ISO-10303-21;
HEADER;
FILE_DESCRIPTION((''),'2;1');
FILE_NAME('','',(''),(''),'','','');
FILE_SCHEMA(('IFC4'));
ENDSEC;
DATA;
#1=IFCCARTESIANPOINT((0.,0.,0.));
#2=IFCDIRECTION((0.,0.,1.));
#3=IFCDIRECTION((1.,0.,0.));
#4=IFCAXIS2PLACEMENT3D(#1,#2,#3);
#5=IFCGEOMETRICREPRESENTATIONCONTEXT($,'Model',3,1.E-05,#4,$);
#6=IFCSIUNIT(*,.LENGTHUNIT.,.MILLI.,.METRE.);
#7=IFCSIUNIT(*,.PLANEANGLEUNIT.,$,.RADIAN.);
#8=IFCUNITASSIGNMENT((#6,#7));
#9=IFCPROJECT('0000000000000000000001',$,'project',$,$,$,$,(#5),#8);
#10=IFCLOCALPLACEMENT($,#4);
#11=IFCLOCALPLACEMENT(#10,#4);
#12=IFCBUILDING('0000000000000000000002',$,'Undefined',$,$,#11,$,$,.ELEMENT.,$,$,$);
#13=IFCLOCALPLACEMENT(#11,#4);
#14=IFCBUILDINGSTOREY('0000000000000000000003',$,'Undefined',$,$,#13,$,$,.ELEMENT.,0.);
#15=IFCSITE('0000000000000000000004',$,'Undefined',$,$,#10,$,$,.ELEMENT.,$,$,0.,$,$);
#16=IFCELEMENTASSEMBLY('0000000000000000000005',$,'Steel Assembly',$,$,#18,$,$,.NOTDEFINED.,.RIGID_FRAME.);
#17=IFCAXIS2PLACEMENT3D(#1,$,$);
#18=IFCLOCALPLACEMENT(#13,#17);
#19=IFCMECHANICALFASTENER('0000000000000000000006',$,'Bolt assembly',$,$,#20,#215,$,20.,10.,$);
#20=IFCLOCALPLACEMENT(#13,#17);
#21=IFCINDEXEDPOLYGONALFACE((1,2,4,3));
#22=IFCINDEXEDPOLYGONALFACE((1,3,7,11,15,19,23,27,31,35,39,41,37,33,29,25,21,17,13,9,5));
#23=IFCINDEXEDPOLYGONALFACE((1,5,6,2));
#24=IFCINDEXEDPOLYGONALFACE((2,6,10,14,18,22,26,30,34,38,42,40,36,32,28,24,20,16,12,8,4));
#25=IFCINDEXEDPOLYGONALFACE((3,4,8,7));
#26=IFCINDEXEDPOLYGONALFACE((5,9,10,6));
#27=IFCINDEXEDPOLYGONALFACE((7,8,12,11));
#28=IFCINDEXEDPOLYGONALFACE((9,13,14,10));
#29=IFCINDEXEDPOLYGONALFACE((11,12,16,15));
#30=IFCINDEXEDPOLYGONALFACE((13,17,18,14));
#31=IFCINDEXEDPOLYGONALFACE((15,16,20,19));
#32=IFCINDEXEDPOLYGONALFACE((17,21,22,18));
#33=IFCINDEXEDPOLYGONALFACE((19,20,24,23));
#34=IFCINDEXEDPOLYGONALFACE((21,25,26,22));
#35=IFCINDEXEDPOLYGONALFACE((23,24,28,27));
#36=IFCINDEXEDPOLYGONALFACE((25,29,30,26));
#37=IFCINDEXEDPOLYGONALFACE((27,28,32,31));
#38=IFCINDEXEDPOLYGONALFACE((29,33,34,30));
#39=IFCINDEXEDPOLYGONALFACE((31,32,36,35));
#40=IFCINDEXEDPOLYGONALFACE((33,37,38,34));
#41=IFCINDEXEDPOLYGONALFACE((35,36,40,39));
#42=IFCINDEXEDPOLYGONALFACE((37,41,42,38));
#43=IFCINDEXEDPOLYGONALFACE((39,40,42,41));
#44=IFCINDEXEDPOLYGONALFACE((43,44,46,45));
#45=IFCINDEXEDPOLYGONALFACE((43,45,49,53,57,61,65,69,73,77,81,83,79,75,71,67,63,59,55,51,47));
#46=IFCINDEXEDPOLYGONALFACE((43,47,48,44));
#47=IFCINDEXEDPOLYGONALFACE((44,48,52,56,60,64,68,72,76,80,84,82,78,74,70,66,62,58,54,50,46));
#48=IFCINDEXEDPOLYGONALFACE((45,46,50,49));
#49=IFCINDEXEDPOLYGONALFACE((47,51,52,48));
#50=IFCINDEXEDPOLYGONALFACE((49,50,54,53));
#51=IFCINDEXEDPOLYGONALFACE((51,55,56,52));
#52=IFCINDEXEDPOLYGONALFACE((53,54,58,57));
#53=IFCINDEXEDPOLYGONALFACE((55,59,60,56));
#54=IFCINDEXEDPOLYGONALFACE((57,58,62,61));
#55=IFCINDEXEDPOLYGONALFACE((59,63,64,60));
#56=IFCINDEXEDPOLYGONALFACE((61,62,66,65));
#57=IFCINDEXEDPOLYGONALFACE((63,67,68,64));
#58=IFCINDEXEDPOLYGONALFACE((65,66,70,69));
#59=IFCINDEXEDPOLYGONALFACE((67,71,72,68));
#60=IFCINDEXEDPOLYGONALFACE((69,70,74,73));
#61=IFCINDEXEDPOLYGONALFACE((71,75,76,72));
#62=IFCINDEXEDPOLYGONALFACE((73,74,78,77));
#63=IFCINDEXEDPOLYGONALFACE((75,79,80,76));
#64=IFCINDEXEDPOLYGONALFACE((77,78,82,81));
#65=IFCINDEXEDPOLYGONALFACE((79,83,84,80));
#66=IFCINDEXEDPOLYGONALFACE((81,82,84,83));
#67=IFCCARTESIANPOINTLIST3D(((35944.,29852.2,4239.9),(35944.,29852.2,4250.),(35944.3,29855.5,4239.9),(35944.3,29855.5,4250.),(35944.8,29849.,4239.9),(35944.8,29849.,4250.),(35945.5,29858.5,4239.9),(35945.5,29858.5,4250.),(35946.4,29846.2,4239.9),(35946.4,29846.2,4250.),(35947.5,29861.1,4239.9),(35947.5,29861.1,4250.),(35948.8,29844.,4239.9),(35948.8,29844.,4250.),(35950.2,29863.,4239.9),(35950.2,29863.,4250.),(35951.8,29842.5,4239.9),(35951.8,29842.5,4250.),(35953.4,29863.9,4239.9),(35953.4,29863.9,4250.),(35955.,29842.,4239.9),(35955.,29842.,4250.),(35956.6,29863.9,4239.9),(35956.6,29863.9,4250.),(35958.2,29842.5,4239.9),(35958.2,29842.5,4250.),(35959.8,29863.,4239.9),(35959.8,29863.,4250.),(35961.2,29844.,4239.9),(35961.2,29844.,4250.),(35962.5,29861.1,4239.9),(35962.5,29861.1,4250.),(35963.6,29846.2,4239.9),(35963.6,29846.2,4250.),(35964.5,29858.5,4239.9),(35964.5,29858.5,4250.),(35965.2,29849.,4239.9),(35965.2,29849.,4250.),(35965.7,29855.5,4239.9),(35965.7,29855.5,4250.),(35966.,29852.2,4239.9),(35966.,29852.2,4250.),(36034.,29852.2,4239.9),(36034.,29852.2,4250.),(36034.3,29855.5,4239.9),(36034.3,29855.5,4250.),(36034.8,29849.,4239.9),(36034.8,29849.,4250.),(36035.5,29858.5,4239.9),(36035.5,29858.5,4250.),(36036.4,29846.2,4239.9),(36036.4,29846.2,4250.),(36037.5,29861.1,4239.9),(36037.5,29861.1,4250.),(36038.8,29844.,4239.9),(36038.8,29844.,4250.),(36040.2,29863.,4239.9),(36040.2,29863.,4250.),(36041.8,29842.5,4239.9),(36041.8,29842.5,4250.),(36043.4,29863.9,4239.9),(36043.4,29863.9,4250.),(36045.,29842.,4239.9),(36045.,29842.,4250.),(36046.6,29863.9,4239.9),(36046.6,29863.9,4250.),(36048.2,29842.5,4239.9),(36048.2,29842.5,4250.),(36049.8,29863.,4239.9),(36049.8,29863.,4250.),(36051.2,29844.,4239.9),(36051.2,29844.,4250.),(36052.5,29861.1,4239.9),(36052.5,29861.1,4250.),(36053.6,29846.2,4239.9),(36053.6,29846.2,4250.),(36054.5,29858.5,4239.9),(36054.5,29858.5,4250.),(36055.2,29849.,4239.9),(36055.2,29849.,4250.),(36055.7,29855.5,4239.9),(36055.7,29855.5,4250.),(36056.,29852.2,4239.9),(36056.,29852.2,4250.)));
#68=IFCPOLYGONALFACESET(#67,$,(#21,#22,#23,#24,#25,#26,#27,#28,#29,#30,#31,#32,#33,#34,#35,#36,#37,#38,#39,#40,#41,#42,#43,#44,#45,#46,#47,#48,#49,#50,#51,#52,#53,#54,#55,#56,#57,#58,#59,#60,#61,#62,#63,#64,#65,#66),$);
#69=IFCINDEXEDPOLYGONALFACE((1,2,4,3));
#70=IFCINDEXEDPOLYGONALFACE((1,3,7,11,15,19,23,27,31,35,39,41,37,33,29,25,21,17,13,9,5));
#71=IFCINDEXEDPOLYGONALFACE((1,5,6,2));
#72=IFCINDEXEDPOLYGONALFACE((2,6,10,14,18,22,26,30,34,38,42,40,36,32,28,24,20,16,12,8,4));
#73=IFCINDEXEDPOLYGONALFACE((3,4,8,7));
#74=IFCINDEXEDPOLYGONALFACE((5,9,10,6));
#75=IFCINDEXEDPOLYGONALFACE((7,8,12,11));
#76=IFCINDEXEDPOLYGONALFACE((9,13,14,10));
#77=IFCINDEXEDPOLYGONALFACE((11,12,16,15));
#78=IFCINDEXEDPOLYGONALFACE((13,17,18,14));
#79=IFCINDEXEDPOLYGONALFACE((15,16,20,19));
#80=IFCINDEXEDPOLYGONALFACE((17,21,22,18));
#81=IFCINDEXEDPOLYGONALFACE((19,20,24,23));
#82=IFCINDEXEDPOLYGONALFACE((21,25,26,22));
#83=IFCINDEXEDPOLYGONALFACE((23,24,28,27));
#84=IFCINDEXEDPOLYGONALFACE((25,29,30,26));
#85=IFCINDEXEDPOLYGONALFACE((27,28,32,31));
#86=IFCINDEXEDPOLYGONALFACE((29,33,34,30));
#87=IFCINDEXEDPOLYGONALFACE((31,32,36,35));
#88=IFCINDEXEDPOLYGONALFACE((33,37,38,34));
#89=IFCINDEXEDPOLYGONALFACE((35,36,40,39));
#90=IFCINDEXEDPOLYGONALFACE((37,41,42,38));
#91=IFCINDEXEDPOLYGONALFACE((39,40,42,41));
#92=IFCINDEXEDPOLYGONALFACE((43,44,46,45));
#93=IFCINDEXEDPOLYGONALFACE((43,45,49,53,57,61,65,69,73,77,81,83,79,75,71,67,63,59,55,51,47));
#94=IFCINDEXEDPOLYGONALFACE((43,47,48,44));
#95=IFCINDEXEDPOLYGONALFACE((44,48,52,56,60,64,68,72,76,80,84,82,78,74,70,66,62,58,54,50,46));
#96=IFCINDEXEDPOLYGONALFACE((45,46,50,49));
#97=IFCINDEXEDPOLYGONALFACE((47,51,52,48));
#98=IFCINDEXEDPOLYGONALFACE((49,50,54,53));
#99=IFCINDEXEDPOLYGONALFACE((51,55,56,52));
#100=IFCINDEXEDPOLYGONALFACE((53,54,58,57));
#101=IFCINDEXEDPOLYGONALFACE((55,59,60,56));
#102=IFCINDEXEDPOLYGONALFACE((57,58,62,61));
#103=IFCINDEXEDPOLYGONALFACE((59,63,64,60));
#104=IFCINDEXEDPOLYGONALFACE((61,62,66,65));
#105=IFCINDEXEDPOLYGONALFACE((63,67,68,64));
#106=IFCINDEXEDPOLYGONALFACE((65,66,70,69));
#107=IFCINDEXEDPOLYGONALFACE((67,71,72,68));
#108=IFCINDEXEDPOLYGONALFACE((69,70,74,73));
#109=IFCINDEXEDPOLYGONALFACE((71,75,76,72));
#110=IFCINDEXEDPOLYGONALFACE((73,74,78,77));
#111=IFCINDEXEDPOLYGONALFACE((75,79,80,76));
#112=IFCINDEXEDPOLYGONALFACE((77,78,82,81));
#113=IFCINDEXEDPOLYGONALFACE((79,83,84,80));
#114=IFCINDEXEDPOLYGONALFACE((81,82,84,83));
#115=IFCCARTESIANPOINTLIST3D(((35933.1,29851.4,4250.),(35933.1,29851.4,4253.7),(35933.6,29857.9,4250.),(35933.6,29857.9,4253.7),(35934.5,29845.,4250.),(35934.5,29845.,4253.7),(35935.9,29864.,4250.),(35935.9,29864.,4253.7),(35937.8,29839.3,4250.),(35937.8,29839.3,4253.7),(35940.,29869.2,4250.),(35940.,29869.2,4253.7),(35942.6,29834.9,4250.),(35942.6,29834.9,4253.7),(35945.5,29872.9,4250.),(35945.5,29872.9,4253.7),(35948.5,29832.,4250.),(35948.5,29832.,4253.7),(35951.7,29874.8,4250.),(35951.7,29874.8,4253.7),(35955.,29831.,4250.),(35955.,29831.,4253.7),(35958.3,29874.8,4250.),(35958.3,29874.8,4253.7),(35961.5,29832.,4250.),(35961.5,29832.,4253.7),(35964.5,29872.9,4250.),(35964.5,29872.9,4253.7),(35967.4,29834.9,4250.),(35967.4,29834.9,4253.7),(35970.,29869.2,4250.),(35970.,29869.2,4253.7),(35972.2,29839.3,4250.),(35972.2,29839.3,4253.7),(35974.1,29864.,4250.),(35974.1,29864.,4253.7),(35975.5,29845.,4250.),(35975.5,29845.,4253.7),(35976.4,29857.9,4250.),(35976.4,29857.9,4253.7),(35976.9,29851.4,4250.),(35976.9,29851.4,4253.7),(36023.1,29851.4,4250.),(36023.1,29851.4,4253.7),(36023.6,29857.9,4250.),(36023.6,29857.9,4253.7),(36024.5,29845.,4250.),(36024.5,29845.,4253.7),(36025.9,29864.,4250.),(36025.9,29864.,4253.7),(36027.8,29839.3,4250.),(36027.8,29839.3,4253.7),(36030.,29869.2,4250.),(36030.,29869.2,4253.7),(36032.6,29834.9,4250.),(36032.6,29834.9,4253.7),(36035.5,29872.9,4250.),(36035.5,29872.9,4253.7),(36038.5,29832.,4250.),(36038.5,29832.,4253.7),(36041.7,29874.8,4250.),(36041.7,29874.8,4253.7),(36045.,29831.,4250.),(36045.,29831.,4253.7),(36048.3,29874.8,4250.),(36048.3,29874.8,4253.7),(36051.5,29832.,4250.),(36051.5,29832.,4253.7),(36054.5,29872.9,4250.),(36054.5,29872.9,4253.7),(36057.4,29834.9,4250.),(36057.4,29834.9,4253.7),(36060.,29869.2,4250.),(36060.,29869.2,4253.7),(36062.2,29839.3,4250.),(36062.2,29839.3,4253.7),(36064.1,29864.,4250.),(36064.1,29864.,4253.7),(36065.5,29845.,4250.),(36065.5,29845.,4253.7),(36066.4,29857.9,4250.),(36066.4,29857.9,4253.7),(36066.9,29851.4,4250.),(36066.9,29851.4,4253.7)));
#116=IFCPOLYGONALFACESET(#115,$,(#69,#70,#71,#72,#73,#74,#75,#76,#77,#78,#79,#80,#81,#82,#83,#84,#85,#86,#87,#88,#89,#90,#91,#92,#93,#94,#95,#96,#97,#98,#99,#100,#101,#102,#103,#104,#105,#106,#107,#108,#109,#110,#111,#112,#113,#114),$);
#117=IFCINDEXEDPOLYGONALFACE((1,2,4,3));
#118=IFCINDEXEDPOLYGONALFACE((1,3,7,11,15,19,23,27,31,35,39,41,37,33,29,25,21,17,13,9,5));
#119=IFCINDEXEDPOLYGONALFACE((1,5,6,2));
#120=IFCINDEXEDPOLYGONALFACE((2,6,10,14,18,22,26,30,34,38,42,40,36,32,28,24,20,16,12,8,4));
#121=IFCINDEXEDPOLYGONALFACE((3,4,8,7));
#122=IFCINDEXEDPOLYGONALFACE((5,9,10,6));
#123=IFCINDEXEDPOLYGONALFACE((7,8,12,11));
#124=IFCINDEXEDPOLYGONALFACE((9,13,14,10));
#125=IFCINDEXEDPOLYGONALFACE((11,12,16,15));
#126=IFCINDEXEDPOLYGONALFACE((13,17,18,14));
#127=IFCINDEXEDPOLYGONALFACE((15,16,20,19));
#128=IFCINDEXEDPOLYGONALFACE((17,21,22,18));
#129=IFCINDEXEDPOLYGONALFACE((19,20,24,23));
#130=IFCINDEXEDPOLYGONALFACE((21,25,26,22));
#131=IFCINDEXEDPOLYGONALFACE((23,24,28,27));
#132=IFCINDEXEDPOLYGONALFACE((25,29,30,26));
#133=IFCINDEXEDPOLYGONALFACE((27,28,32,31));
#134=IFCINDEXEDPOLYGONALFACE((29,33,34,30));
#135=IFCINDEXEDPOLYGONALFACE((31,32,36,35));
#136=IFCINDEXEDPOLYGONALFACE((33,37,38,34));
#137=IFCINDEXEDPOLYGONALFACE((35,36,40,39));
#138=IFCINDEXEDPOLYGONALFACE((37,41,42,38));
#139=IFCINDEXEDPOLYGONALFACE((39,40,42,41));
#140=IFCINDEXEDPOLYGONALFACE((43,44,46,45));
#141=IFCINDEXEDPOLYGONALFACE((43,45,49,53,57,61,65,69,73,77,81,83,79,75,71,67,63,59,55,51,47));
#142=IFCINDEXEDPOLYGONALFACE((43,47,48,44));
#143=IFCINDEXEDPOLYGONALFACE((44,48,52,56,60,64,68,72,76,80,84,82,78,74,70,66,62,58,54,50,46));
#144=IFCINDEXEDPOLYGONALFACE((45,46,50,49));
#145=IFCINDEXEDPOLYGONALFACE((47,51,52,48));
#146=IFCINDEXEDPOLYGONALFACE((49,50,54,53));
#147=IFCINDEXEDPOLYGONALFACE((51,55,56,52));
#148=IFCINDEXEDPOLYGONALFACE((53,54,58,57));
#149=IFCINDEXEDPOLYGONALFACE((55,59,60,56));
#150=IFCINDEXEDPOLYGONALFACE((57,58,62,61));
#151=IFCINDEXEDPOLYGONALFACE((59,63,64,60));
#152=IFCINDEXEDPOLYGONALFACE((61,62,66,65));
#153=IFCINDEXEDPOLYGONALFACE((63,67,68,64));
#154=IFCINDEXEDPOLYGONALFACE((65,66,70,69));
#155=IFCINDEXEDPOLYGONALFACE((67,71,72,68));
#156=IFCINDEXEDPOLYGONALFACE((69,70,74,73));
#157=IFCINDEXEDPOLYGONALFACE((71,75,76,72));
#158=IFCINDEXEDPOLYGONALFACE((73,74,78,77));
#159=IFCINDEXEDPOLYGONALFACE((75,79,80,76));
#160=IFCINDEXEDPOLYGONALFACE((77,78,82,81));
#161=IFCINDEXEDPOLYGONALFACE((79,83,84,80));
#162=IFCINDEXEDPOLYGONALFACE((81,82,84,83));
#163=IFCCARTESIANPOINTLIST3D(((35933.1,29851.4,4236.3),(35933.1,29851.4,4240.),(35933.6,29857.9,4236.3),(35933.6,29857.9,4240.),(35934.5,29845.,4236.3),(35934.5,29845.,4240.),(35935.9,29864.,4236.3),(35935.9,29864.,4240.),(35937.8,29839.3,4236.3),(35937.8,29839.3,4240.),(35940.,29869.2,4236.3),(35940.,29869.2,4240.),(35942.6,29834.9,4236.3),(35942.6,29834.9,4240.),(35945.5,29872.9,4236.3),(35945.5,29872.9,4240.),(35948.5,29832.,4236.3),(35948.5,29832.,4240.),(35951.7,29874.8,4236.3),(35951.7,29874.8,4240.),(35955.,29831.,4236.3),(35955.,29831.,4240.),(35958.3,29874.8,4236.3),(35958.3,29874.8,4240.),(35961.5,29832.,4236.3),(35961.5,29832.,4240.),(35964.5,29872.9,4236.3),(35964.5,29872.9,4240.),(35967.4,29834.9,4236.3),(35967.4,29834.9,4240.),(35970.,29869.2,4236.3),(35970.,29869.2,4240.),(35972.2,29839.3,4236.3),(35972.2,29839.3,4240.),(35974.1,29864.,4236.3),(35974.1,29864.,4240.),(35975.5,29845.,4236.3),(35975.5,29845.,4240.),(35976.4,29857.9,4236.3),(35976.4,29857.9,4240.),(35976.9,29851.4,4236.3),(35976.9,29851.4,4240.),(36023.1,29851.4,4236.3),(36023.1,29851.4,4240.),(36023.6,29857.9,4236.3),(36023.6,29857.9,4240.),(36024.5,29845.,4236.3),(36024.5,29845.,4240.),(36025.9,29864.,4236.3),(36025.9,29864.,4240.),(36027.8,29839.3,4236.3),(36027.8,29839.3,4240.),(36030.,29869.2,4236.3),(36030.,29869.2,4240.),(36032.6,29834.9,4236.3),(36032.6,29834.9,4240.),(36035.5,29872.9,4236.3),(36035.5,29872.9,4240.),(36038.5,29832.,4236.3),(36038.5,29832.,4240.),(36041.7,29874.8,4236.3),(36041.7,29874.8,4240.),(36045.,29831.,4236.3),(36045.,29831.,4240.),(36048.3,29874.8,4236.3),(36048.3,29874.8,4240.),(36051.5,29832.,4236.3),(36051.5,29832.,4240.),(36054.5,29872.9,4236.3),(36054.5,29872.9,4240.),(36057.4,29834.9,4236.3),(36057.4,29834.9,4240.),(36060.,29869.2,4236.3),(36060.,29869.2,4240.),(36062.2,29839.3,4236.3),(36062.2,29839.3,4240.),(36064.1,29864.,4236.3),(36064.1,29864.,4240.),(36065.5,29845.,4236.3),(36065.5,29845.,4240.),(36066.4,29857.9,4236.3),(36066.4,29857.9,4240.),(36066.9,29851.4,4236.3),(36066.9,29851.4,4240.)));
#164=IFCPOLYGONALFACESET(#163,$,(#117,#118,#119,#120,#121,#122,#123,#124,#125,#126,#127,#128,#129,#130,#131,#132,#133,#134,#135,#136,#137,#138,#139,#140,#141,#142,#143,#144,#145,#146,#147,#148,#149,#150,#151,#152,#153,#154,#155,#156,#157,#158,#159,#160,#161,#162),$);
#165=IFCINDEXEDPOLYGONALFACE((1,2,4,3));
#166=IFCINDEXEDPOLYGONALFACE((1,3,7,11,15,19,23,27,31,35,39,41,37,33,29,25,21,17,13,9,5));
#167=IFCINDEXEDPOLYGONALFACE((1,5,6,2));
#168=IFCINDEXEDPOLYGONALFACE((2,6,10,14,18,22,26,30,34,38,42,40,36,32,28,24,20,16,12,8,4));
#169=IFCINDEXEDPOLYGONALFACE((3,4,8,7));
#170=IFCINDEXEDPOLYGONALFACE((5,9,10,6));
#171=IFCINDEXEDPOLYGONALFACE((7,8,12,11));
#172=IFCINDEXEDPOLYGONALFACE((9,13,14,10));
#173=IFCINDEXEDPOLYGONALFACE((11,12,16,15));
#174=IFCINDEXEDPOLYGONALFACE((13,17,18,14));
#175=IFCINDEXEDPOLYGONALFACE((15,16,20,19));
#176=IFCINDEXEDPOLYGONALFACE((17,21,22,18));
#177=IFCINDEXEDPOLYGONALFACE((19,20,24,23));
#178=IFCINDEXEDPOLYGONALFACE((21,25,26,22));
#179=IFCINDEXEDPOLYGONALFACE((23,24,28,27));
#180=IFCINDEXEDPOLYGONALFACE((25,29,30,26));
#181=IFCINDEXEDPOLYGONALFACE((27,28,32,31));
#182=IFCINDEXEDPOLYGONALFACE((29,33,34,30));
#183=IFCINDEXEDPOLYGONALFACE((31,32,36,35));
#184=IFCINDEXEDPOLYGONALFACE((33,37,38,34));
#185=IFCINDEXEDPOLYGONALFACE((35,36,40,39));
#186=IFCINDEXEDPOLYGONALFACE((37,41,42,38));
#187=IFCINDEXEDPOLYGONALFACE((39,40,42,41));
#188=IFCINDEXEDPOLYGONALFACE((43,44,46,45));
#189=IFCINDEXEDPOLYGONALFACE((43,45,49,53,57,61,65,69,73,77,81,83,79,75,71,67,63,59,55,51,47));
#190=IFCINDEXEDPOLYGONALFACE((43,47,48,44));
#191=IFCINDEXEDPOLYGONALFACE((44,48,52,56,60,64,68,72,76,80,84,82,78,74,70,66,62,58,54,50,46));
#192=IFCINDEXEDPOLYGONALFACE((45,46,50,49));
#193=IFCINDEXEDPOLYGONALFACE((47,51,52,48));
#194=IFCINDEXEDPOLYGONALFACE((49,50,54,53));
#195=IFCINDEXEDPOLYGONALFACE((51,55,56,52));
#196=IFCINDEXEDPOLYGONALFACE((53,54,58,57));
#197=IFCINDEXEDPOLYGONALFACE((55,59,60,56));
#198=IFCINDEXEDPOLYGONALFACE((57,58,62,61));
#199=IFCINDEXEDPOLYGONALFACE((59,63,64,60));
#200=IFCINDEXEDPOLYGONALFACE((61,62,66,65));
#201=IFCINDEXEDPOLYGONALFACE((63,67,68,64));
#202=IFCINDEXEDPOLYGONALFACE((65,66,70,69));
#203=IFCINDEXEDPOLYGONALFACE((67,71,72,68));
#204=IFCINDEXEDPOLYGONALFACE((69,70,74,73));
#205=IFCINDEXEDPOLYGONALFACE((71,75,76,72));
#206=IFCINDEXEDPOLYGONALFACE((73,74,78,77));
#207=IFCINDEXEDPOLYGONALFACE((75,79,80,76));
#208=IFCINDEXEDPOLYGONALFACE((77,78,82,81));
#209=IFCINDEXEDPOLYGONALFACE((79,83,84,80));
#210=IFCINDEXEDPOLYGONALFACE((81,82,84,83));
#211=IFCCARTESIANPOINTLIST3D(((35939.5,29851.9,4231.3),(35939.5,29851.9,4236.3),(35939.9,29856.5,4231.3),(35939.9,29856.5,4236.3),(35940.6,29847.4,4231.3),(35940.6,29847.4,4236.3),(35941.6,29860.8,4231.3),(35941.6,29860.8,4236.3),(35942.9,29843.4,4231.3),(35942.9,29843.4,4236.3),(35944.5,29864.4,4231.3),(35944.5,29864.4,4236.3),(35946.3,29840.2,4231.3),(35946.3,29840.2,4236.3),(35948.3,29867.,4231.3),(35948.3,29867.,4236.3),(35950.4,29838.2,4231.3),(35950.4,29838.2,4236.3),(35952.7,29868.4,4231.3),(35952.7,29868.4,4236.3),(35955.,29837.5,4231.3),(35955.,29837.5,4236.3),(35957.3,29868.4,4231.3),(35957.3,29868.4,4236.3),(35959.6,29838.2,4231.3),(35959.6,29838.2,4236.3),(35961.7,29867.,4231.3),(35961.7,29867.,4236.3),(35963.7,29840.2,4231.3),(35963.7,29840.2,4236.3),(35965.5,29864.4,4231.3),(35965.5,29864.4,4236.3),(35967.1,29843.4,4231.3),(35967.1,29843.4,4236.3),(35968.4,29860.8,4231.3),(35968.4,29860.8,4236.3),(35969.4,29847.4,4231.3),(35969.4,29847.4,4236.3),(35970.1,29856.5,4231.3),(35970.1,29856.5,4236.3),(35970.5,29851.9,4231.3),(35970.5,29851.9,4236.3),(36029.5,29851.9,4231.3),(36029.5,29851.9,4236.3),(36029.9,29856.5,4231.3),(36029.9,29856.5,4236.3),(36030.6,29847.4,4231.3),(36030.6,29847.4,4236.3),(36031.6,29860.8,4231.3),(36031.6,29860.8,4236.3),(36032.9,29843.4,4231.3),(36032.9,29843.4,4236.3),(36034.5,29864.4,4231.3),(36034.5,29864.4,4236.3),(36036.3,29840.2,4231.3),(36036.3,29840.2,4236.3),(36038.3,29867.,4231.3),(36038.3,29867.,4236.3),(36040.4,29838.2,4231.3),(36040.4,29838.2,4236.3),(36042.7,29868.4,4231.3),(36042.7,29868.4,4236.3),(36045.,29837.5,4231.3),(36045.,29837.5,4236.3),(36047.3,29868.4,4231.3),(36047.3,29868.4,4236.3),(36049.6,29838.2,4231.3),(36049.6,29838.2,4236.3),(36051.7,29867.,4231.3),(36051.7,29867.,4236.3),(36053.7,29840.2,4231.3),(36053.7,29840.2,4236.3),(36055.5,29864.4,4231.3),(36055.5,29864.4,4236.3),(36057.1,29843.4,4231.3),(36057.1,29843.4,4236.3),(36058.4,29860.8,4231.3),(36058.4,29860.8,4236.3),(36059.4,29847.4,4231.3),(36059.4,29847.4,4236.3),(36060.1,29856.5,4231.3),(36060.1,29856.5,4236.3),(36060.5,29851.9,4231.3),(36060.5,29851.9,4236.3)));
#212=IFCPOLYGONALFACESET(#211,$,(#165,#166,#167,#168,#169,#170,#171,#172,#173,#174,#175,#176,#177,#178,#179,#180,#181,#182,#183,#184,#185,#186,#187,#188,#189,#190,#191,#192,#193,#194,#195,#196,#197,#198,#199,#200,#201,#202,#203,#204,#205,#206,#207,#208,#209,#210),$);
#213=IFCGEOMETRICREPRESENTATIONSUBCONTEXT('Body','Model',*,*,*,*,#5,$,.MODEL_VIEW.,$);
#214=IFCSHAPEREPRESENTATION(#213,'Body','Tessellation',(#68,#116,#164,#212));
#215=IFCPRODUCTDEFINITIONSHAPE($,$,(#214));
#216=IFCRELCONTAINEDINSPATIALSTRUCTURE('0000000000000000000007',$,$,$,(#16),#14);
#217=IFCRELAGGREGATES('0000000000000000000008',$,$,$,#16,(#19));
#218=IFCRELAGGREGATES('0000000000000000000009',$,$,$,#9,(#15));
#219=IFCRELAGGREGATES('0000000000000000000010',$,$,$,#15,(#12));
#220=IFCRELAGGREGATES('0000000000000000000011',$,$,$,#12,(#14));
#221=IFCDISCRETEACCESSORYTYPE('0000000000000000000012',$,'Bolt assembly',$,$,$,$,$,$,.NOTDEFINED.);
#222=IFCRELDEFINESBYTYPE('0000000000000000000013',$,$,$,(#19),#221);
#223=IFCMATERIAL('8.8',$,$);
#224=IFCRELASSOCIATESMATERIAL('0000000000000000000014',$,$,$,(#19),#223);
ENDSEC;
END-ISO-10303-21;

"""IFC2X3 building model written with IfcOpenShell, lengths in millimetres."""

from ifc_helpers import new_model, si_unit, frame, origin_with_axes, origin_2d_with_axis, place, context, subcontext, project, spatial, circle, extrude, source, transform, mapped, material, type_object, element, aggregate, save


model = new_model("IFC2X3")

# Units and contexts
model_context = context("Model", 3, precision=1e-05, world=origin_with_axes())
body_context = subcontext(model_context, "Body", "Model", "MODEL_VIEW")
ifc_project = project(units=[si_unit("LENGTHUNIT", "METRE", prefix="MILLI"), si_unit("PLANEANGLEUNIT", "RADIAN")], contexts=[model_context])

# Site, building, storey
site_placement = place(None, origin_with_axes())
site = spatial("IfcSite", under=ifc_project, at=site_placement, Name="Undefined", CompositionType="ELEMENT", RefElevation=0.0)
building_placement = place(site_placement, origin_with_axes())
building = spatial("IfcBuilding", under=site, at=building_placement, Name="Undefined", CompositionType="ELEMENT")
storey_placement = place(building_placement, origin_with_axes())
storey = spatial("IfcBuildingStorey", under=building, at=storey_placement, Name="Undefined", CompositionType="ELEMENT", Elevation=0.0)

# Element assembly
assembly_1_placement = place(storey_placement, origin_with_axes())
assembly_1 = element("IfcElementAssembly", 1, at=assembly_1_placement, inside=storey, Name="Steel Assembly", AssemblyPlace="NOTDEFINED", PredefinedType="RIGID_FRAME")

# Shared definitions
ifc_material_1 = material(Name="8.8")
discrete_accessory_type_1 = type_object("IfcDiscreteAccessoryType", Name="Bolt assembly")

# Mechanical fastener
shared_shape_1 = source(origin_with_axes(), body_context, "Body", "SweptSolid", [
    extrude(circle(Radius=11.0, at=origin_2d_with_axis()), frame((0.0, -10.0, 0.0), z_axis=(0.0, 1.0, 0.0), x_axis=(1.0, 0.0, 0.0)), (0.0, 0.0, 1.0), 10.1),
    extrude(circle(Radius=22.0, at=origin_2d_with_axis()), frame((0.0, -13.7, 0.0), z_axis=(0.0, 1.0, 0.0), x_axis=(1.0, 0.0, 0.0)), (0.0, 0.0, 1.0), 3.7),
    extrude(circle(Radius=22.0, at=origin_2d_with_axis()), frame((0.0, 0.0, 0.0), z_axis=(0.0, 1.0, 0.0), x_axis=(1.0, 0.0, 0.0)), (0.0, 0.0, 1.0), 3.7),
    extrude(circle(Radius=15.5, at=origin_2d_with_axis()), frame((0.0, 3.7, 0.0), z_axis=(0.0, 1.0, 0.0), x_axis=(1.0, 0.0, 0.0)), (0.0, 0.0, 1.0), 5.0),
])
mechanical_fastener_1_placement = place(assembly_1_placement, frame((36000.0, 29853.0, 4240.0), z_axis=(1.0, 0.0, 0.0), x_axis=(0.0, -1.0, 0.0)))
mechanical_fastener_1 = element("IfcMechanicalFastener", 2, at=mechanical_fastener_1_placement, type_object=discrete_accessory_type_1, material=ifc_material_1, Name="Bolt assembly", NominalDiameter=20.0, NominalLength=10.0, context=body_context, shape_type="MappedRepresentation", body=[
    mapped(shared_shape_1, transform((0.0, 0.0, 45.0))),
    mapped(shared_shape_1, transform((0.0, 0.0, -45.0))),
])
aggregate(assembly_1, [mechanical_fastener_1])

save(model, "model.ifc")
